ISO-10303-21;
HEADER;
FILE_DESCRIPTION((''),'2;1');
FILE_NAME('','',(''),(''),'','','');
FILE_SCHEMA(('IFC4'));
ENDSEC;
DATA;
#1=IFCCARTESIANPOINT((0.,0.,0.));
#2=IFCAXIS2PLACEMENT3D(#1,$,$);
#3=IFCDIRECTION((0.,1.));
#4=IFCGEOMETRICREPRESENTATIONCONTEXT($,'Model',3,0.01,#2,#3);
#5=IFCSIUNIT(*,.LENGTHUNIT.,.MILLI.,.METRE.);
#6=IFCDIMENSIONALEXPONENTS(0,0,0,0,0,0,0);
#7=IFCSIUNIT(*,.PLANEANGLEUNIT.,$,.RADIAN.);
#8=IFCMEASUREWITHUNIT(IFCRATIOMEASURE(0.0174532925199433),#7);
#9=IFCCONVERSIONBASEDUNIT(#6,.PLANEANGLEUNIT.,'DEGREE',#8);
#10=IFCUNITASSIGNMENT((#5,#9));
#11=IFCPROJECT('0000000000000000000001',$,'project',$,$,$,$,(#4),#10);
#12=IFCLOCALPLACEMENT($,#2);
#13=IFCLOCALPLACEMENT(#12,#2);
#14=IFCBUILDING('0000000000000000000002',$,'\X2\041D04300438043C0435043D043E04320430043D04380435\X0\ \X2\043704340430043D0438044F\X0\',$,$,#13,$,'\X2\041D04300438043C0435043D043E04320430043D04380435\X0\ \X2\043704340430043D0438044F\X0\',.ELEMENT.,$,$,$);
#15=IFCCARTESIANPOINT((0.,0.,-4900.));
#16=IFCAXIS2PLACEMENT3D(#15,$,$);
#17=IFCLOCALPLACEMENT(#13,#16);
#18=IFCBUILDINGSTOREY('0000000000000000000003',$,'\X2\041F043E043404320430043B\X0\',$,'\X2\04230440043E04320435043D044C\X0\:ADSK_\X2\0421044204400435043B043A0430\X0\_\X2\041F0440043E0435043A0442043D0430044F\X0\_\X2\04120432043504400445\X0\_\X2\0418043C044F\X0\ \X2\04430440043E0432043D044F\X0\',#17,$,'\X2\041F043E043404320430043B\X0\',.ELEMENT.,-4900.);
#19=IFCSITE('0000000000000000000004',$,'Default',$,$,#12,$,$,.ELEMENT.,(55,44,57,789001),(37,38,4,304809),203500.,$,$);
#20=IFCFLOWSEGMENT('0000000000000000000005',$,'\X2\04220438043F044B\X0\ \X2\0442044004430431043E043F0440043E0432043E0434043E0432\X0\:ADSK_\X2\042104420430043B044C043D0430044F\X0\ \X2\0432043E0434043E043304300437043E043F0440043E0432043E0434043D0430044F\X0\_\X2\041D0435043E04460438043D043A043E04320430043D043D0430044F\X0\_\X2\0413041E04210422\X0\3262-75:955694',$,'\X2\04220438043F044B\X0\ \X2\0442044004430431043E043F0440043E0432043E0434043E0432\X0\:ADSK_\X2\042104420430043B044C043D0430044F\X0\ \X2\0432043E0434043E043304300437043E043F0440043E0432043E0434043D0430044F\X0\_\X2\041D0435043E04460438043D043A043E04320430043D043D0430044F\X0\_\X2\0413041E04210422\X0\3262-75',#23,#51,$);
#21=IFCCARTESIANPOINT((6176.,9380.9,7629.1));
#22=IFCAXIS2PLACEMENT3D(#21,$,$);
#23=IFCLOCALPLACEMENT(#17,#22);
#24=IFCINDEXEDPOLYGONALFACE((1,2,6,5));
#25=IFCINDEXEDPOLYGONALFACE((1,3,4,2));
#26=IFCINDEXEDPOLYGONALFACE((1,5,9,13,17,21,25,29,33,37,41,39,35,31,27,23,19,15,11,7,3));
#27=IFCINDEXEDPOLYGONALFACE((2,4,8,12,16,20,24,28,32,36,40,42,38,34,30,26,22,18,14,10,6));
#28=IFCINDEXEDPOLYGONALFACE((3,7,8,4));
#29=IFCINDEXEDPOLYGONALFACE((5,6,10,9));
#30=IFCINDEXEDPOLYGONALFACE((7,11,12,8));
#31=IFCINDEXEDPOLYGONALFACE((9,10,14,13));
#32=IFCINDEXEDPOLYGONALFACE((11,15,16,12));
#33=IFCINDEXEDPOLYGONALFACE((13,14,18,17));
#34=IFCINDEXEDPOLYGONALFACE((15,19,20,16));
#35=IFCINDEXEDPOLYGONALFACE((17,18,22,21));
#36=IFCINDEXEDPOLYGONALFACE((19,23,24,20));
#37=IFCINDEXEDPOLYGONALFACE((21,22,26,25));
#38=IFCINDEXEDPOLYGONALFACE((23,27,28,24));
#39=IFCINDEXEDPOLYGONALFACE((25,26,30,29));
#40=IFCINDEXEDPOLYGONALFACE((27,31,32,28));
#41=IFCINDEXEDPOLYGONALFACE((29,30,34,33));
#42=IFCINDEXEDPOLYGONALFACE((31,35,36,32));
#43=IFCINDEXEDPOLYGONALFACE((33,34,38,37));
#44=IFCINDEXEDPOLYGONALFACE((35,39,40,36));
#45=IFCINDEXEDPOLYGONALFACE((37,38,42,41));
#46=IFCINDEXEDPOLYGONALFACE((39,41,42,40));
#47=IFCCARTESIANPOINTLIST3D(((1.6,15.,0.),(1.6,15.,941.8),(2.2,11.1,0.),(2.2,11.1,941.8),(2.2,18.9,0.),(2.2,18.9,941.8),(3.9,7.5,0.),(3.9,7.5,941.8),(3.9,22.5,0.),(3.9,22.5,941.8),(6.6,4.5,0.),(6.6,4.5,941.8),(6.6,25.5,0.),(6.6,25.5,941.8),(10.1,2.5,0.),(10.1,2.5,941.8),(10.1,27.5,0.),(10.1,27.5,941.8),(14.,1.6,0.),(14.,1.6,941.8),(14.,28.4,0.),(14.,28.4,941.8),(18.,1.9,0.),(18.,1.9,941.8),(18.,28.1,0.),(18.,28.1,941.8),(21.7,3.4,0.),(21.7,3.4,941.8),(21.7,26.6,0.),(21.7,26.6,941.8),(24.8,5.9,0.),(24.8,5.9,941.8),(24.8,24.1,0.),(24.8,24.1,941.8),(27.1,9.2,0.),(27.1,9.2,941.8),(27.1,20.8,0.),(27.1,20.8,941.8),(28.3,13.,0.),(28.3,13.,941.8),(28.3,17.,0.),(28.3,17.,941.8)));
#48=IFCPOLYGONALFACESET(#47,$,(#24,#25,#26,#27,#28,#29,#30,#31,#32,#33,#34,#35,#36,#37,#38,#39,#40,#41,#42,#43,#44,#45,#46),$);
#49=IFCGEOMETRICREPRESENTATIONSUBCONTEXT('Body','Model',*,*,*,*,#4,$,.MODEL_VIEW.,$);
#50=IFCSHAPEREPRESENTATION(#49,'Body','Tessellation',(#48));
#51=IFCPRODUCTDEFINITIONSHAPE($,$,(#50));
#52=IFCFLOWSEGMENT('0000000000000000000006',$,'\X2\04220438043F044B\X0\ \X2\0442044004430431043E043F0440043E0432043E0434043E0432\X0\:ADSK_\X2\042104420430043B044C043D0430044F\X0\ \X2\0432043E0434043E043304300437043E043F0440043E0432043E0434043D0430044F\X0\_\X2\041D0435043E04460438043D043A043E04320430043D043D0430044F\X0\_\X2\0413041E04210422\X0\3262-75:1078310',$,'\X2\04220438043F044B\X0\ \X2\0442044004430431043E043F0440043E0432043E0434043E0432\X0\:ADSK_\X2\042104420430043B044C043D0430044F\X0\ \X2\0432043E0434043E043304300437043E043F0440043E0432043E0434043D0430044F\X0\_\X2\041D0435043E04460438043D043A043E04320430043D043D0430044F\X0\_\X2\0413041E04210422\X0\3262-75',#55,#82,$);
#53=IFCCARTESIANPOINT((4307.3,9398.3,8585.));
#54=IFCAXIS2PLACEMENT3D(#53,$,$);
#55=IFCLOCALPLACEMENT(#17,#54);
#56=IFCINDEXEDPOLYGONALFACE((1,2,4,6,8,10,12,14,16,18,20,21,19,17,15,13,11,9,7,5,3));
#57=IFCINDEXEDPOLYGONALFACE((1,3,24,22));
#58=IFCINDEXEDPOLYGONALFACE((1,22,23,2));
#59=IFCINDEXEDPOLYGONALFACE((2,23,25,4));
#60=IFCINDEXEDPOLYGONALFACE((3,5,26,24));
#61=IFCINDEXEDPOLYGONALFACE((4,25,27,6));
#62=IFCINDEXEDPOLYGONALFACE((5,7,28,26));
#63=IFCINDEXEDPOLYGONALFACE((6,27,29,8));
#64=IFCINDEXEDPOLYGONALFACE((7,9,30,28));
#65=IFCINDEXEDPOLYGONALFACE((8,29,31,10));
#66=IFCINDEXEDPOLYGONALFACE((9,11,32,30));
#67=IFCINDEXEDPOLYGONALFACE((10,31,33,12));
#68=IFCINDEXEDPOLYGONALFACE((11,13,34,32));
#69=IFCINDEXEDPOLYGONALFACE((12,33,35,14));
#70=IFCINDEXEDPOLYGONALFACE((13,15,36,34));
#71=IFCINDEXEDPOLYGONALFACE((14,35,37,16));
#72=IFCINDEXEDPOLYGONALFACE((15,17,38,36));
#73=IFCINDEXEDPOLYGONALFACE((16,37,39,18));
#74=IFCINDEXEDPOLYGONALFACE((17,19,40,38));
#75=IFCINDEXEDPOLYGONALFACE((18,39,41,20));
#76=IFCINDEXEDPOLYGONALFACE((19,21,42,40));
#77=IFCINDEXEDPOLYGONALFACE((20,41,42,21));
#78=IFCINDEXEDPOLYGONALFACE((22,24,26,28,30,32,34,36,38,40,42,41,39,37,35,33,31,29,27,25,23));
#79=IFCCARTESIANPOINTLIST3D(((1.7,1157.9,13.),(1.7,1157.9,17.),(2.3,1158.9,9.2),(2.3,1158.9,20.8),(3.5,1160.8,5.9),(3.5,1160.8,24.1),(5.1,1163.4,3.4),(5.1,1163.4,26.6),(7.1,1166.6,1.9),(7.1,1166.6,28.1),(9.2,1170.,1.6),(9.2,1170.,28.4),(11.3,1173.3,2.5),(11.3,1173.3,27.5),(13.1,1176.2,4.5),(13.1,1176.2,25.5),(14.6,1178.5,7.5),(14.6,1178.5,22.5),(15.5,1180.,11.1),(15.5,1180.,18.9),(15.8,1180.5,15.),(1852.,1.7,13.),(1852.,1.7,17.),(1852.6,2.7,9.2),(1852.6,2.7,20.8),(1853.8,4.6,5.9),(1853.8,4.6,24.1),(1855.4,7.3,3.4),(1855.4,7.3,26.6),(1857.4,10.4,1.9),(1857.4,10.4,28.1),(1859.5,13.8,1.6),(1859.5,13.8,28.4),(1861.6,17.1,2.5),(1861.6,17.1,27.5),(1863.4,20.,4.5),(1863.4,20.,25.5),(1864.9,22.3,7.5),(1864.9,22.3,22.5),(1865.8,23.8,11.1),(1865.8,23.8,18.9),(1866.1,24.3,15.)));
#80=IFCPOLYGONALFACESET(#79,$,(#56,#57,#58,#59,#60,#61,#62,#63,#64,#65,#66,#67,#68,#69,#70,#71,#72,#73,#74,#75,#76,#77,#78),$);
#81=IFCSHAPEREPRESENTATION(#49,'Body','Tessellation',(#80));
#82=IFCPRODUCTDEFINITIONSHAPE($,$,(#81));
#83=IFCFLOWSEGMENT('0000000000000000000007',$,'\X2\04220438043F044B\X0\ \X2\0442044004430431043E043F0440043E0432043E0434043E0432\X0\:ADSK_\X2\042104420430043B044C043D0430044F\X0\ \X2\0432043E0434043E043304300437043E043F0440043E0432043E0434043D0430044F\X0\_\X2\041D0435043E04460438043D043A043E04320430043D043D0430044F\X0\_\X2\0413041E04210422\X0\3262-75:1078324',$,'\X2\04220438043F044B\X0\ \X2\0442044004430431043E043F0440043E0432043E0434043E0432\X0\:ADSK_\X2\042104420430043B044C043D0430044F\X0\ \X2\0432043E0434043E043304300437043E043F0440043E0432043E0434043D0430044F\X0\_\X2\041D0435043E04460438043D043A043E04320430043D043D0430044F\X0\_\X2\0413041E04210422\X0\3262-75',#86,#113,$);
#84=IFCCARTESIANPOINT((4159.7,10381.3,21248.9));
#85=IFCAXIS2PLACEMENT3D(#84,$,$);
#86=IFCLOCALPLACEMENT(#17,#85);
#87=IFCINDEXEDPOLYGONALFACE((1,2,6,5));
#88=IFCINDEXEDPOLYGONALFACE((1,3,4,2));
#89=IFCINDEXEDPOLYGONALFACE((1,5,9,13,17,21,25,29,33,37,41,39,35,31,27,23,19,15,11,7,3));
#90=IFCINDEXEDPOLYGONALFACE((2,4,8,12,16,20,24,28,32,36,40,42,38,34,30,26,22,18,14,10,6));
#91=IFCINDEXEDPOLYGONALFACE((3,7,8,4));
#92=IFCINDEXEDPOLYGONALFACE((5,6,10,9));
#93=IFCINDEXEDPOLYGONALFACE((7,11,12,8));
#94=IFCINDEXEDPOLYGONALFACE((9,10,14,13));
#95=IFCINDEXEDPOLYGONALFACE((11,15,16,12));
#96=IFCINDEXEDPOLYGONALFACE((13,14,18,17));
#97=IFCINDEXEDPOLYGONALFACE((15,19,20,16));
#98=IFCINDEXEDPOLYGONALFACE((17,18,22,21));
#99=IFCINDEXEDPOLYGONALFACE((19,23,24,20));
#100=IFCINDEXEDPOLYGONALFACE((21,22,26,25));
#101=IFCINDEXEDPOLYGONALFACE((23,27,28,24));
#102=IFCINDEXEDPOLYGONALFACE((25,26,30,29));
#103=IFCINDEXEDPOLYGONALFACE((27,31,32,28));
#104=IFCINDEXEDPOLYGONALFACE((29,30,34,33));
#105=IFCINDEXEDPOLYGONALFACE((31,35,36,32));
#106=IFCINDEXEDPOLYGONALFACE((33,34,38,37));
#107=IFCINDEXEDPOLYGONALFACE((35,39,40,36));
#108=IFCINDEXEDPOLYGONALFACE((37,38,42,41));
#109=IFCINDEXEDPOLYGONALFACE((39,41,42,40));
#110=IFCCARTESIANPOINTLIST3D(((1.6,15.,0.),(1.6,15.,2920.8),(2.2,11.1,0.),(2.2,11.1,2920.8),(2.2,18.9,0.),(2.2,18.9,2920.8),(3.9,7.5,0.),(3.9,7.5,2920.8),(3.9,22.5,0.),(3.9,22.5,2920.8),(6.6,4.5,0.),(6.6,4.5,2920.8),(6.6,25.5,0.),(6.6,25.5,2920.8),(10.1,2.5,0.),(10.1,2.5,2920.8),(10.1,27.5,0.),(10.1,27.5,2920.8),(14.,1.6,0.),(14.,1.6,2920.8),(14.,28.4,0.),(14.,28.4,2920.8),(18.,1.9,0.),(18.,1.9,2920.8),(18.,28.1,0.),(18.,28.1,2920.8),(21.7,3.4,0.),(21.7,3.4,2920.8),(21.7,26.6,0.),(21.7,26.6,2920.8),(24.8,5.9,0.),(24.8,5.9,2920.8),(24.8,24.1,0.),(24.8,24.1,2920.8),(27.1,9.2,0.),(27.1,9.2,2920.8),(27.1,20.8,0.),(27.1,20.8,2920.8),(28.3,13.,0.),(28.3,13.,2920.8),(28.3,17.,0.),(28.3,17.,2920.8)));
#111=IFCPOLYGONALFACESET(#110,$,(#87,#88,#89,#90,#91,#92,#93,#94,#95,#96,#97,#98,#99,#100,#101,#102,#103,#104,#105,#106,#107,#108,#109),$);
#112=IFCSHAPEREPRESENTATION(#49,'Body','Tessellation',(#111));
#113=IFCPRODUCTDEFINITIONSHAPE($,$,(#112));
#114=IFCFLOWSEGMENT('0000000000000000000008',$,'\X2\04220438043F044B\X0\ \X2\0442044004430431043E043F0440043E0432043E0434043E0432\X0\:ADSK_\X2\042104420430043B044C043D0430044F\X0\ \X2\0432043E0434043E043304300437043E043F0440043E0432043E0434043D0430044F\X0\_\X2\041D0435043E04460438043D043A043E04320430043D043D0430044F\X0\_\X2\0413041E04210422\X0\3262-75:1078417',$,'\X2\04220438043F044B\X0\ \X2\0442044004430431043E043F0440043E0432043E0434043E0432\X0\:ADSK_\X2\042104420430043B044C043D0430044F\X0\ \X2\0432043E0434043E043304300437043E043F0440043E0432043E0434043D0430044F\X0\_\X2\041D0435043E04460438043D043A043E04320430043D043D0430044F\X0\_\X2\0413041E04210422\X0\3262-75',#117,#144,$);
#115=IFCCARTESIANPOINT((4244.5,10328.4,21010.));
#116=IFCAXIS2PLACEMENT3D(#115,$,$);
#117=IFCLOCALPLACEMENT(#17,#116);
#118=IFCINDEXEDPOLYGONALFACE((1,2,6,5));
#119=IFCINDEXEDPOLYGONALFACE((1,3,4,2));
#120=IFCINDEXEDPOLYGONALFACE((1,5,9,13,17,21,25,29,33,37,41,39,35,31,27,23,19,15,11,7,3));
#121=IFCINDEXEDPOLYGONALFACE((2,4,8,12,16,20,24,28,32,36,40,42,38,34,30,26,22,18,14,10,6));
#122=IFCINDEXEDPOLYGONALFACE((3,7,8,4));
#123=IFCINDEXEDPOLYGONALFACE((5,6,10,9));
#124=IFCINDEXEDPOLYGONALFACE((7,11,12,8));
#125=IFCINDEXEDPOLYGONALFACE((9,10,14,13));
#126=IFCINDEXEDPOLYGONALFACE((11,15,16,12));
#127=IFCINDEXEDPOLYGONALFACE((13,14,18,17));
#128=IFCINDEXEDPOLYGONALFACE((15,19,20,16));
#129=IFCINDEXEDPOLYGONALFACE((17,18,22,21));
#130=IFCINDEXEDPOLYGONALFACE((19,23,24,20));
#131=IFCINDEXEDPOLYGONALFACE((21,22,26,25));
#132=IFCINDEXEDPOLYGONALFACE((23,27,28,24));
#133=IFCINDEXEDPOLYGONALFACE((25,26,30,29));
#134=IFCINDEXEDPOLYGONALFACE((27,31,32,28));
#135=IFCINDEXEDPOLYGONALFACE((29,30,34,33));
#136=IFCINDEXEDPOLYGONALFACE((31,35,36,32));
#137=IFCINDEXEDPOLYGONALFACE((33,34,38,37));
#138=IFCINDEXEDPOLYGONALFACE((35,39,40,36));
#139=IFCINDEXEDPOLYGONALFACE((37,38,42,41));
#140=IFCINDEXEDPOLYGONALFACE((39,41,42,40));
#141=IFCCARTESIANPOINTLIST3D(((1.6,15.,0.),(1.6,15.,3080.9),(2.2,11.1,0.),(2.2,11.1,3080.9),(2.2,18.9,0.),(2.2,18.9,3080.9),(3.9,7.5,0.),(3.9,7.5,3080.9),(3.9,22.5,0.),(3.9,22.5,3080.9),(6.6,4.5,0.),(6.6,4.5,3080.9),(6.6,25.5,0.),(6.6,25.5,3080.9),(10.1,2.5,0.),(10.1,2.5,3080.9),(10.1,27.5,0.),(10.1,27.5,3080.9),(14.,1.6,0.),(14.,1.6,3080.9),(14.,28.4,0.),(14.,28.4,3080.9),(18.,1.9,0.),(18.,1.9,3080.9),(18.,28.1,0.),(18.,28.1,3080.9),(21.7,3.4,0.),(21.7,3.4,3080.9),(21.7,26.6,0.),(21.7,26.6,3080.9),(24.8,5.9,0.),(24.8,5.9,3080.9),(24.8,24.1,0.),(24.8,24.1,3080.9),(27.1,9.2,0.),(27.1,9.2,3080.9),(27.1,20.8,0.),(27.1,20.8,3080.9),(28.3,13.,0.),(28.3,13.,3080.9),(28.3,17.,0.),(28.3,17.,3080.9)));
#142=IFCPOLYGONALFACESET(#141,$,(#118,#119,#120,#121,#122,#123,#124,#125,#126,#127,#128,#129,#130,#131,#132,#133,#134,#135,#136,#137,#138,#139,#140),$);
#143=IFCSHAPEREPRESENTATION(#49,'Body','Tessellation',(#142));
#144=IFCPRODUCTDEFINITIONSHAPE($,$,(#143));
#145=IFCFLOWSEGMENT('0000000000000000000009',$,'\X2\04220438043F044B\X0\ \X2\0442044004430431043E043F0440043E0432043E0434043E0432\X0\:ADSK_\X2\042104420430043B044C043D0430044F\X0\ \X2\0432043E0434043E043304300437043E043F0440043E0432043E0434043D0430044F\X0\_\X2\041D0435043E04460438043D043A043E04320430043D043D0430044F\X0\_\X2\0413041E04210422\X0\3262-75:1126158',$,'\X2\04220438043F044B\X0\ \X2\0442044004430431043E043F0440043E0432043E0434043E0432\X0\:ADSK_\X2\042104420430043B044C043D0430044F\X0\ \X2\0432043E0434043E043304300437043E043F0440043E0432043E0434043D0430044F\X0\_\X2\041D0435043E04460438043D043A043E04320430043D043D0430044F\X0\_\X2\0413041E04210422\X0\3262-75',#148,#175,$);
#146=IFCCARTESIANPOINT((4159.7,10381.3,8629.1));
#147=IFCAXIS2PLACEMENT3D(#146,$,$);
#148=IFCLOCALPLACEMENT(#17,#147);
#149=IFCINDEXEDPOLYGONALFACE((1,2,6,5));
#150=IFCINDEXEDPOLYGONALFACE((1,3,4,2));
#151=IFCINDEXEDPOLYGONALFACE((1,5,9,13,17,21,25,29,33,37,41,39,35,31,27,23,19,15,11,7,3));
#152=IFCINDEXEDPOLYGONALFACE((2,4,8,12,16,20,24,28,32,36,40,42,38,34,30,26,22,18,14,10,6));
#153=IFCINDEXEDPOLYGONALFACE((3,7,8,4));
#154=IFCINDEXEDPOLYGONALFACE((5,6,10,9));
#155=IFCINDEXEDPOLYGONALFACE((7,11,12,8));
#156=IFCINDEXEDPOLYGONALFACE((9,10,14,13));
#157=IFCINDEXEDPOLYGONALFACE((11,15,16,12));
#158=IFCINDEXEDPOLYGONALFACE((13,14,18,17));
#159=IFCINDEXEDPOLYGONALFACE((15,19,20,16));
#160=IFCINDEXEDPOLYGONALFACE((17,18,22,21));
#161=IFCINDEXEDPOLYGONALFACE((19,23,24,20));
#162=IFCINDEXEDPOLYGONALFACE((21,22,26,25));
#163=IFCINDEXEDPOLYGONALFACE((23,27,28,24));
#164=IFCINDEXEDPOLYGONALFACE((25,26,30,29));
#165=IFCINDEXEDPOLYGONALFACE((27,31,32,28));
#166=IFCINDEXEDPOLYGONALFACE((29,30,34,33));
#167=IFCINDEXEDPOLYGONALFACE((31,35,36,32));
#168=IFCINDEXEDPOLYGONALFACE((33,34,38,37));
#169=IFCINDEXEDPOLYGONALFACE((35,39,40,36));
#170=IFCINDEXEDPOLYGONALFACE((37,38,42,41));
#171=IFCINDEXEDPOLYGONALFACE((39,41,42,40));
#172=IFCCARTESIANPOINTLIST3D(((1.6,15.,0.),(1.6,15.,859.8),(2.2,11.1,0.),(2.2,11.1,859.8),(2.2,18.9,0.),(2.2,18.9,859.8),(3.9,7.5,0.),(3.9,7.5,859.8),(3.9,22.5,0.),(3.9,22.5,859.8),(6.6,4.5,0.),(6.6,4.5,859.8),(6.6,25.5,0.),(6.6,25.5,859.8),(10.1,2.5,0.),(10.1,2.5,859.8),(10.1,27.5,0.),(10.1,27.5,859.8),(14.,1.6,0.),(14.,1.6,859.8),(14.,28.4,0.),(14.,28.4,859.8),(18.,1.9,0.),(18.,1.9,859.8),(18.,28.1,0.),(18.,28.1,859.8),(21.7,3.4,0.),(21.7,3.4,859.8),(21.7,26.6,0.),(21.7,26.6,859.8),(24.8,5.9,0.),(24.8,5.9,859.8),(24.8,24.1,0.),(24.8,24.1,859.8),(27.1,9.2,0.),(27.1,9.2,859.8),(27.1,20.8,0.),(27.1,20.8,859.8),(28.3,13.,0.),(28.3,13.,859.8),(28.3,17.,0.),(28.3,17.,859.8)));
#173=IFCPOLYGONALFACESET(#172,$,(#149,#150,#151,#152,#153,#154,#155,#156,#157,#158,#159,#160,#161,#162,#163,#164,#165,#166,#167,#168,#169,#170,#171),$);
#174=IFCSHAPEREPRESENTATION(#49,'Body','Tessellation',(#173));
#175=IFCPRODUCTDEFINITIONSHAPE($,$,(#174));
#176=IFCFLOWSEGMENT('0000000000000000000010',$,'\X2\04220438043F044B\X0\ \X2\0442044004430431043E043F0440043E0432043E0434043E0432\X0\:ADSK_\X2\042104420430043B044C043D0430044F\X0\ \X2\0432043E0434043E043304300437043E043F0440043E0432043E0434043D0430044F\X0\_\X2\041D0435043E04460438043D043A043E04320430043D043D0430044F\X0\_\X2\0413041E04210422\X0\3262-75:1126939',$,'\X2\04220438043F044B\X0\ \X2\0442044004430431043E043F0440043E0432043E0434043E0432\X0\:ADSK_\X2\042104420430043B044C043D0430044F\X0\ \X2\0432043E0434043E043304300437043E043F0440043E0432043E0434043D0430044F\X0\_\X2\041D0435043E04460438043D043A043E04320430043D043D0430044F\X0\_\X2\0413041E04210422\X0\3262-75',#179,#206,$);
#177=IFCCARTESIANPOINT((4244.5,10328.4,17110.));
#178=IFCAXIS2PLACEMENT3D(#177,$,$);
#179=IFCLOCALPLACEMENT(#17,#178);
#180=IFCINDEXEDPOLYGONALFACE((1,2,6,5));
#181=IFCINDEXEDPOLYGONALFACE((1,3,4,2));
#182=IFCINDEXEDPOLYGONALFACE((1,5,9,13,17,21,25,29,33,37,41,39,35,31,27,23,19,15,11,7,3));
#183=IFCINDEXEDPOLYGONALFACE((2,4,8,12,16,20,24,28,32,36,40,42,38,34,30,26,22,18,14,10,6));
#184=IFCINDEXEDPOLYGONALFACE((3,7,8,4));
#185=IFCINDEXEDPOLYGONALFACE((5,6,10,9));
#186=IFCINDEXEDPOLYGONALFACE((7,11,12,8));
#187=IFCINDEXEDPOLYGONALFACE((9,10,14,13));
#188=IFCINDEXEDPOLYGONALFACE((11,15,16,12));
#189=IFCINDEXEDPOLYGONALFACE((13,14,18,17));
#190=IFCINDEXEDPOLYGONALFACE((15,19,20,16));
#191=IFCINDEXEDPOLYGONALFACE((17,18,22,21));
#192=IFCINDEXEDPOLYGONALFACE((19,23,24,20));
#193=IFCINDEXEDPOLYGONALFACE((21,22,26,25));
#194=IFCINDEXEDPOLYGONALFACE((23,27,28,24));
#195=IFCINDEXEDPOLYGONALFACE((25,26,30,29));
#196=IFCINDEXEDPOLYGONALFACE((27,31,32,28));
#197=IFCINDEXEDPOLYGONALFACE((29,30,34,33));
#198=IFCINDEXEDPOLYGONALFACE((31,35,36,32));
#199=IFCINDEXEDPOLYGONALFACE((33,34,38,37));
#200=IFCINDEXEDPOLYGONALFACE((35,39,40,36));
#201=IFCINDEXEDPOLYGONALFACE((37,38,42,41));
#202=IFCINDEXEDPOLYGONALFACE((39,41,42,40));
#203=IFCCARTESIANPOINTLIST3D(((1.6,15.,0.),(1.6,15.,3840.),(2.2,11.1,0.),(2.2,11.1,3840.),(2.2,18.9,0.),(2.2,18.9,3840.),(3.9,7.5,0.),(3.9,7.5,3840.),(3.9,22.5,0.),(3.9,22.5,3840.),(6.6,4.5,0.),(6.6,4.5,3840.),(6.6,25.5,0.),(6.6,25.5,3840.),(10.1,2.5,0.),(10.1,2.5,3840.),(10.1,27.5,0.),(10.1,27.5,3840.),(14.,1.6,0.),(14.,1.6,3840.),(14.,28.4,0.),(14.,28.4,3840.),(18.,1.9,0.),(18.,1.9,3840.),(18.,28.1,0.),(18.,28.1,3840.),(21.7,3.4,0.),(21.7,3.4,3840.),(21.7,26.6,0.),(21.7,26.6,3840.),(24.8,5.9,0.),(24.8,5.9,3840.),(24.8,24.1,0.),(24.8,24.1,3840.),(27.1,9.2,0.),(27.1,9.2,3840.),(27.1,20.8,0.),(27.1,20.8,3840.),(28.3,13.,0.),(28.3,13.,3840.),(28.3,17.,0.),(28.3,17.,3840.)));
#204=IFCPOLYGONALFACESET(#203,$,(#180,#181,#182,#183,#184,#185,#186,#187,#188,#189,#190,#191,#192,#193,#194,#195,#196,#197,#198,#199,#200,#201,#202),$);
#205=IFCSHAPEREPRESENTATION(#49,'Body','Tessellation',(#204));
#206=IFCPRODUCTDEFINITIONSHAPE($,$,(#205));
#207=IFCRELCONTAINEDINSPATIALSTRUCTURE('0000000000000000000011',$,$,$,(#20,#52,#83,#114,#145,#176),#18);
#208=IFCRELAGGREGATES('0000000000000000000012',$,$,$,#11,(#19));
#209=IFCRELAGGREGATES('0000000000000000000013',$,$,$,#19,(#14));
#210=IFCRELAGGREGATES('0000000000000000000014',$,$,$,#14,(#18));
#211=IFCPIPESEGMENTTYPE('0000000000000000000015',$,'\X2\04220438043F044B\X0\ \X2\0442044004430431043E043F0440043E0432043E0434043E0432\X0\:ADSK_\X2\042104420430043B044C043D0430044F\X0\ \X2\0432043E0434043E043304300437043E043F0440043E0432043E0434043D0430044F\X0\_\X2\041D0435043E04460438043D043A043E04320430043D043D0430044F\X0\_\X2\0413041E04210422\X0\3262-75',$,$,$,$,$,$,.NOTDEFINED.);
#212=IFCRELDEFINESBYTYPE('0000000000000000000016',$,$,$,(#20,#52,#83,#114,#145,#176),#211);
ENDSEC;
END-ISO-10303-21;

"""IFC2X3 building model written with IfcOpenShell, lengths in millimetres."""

from ifc_helpers import new_model, entity, si_unit, converted_unit, direction, frame, origin, origin_2d_with_axis, place, context, subcontext, project, spatial, circle, extrude, type_object, element, save


model = new_model("IFC2X3")

# Units and contexts
model_context = context("Model", 3, precision=0.01, world=origin(), true_north=direction((0.0, 1.0)))
body_context = subcontext(model_context, "Body", "Model", "MODEL_VIEW")
ifc_project = project(units=[si_unit("LENGTHUNIT", "METRE", prefix="MILLI"), converted_unit("PLANEANGLEUNIT", "DEGREE", entity("IfcRatioMeasure", 0.0174532925199433), si_unit("PLANEANGLEUNIT", "RADIAN"), dimensions=[0, 0, 0, 0, 0, 0, 0])], contexts=[model_context])

# Site, building, storey
site_placement = place(None, origin())
site = spatial("IfcSite", under=ifc_project, at=site_placement, Name="Default", CompositionType="ELEMENT", RefLatitude=(55, 44, 57, 789001), RefLongitude=(37, 38, 4, 304809), RefElevation=203500.0)
building_placement = place(site_placement, origin())
building = spatial("IfcBuilding", under=site, at=building_placement, Name="Наименование здания", LongName="Наименование здания", CompositionType="ELEMENT")
storey_placement = place(building_placement, frame((0.0, 0.0, -4900.0)))
storey = spatial("IfcBuildingStorey", under=building, at=storey_placement, Name="Подвал", ObjectType="Уровень:ADSK_Стрелка_Проектная_Вверх_Имя уровня", LongName="Подвал", CompositionType="ELEMENT", Elevation=-4900.0)

# Flow segments
pipe_segment_type = type_object("IfcPipeSegmentType", Name="Типы трубопроводов:ADSK_Стальная водогазопроводная_Неоцинкованная_ГОСТ3262-75", PredefinedType="NOTDEFINED")
flow_segment_1_placement = place(storey_placement, frame((6176.0, 9380.9, 7629.1)))
element("IfcFlowSegment", 1, at=flow_segment_1_placement, inside=storey, type_object=pipe_segment_type, Name="Типы трубопроводов:ADSK_Стальная водогазопроводная_Неоцинкованная_ГОСТ3262-75:955694", ObjectType="Типы трубопроводов:ADSK_Стальная водогазопроводная_Неоцинкованная_ГОСТ3262-75", context=body_context, shape_type="SweptSolid", body=[
    extrude(circle(Radius=13.4, at=origin_2d_with_axis()), frame((15.0, 15.0, 0.0), z_axis=(0.0, 0.0, 1.0), x_axis=(-1.0, 0.0, 0.0)), (0.0, 0.0, 1.0), 941.8),
])
flow_segment_2_placement = place(storey_placement, frame((4307.3, 9398.3, 8585.0)))
element("IfcFlowSegment", 2, at=flow_segment_2_placement, inside=storey, type_object=pipe_segment_type, Name="Типы трубопроводов:ADSK_Стальная водогазопроводная_Неоцинкованная_ГОСТ3262-75:1078310", ObjectType="Типы трубопроводов:ADSK_Стальная водогазопроводная_Неоцинкованная_ГОСТ3262-75", context=body_context, shape_type="SweptSolid", body=[
    extrude(circle(Radius=13.4, at=origin_2d_with_axis()), frame((8.7, 1169.1, 15.0), z_axis=(0.848053, -0.529912, 0.0), x_axis=(0.529912, 0.848053, 0.0)), (0.0, 0.0, 1.0), 2181.8),
])
flow_segment_3_placement = place(storey_placement, frame((4159.7, 10381.3, 21248.9)))
element("IfcFlowSegment", 3, at=flow_segment_3_placement, inside=storey, type_object=pipe_segment_type, Name="Типы трубопроводов:ADSK_Стальная водогазопроводная_Неоцинкованная_ГОСТ3262-75:1078324", ObjectType="Типы трубопроводов:ADSK_Стальная водогазопроводная_Неоцинкованная_ГОСТ3262-75", context=body_context, shape_type="SweptSolid", body=[
    extrude(circle(Radius=13.4, at=origin_2d_with_axis()), frame((15.0, 15.0, 0.0), z_axis=(0.0, 0.0, 1.0), x_axis=(-1.0, 0.0, 0.0)), (0.0, 0.0, 1.0), 2920.8),
])
flow_segment_4_placement = place(storey_placement, frame((4244.5, 10328.4, 21010.0)))
element("IfcFlowSegment", 4, at=flow_segment_4_placement, inside=storey, type_object=pipe_segment_type, Name="Типы трубопроводов:ADSK_Стальная водогазопроводная_Неоцинкованная_ГОСТ3262-75:1078417", ObjectType="Типы трубопроводов:ADSK_Стальная водогазопроводная_Неоцинкованная_ГОСТ3262-75", context=body_context, shape_type="SweptSolid", body=[
    extrude(circle(Radius=13.4, at=origin_2d_with_axis()), frame((15.0, 15.0, 0.0), z_axis=(0.0, 0.0, 1.0), x_axis=(-1.0, 0.0, 0.0)), (0.0, 0.0, 1.0), 3080.9),
])
flow_segment_5_placement = place(storey_placement, frame((4159.7, 10381.3, 8629.1)))
element("IfcFlowSegment", 5, at=flow_segment_5_placement, inside=storey, type_object=pipe_segment_type, Name="Типы трубопроводов:ADSK_Стальная водогазопроводная_Неоцинкованная_ГОСТ3262-75:1126158", ObjectType="Типы трубопроводов:ADSK_Стальная водогазопроводная_Неоцинкованная_ГОСТ3262-75", context=body_context, shape_type="SweptSolid", body=[
    extrude(circle(Radius=13.4, at=origin_2d_with_axis()), frame((15.0, 15.0, 0.0), z_axis=(0.0, 0.0, 1.0), x_axis=(-1.0, 0.0, 0.0)), (0.0, 0.0, 1.0), 859.8),
])
flow_segment_6_placement = place(storey_placement, frame((4244.5, 10328.4, 17110.0)))
element("IfcFlowSegment", 6, at=flow_segment_6_placement, inside=storey, type_object=pipe_segment_type, Name="Типы трубопроводов:ADSK_Стальная водогазопроводная_Неоцинкованная_ГОСТ3262-75:1126939", ObjectType="Типы трубопроводов:ADSK_Стальная водогазопроводная_Неоцинкованная_ГОСТ3262-75", context=body_context, shape_type="SweptSolid", body=[
    extrude(circle(Radius=13.4, at=origin_2d_with_axis()), frame((15.0, 15.0, 0.0), z_axis=(0.0, 0.0, 1.0), x_axis=(-1.0, 0.0, 0.0)), (0.0, 0.0, 1.0), 3840.0),
])

save(model, "model.ifc")
